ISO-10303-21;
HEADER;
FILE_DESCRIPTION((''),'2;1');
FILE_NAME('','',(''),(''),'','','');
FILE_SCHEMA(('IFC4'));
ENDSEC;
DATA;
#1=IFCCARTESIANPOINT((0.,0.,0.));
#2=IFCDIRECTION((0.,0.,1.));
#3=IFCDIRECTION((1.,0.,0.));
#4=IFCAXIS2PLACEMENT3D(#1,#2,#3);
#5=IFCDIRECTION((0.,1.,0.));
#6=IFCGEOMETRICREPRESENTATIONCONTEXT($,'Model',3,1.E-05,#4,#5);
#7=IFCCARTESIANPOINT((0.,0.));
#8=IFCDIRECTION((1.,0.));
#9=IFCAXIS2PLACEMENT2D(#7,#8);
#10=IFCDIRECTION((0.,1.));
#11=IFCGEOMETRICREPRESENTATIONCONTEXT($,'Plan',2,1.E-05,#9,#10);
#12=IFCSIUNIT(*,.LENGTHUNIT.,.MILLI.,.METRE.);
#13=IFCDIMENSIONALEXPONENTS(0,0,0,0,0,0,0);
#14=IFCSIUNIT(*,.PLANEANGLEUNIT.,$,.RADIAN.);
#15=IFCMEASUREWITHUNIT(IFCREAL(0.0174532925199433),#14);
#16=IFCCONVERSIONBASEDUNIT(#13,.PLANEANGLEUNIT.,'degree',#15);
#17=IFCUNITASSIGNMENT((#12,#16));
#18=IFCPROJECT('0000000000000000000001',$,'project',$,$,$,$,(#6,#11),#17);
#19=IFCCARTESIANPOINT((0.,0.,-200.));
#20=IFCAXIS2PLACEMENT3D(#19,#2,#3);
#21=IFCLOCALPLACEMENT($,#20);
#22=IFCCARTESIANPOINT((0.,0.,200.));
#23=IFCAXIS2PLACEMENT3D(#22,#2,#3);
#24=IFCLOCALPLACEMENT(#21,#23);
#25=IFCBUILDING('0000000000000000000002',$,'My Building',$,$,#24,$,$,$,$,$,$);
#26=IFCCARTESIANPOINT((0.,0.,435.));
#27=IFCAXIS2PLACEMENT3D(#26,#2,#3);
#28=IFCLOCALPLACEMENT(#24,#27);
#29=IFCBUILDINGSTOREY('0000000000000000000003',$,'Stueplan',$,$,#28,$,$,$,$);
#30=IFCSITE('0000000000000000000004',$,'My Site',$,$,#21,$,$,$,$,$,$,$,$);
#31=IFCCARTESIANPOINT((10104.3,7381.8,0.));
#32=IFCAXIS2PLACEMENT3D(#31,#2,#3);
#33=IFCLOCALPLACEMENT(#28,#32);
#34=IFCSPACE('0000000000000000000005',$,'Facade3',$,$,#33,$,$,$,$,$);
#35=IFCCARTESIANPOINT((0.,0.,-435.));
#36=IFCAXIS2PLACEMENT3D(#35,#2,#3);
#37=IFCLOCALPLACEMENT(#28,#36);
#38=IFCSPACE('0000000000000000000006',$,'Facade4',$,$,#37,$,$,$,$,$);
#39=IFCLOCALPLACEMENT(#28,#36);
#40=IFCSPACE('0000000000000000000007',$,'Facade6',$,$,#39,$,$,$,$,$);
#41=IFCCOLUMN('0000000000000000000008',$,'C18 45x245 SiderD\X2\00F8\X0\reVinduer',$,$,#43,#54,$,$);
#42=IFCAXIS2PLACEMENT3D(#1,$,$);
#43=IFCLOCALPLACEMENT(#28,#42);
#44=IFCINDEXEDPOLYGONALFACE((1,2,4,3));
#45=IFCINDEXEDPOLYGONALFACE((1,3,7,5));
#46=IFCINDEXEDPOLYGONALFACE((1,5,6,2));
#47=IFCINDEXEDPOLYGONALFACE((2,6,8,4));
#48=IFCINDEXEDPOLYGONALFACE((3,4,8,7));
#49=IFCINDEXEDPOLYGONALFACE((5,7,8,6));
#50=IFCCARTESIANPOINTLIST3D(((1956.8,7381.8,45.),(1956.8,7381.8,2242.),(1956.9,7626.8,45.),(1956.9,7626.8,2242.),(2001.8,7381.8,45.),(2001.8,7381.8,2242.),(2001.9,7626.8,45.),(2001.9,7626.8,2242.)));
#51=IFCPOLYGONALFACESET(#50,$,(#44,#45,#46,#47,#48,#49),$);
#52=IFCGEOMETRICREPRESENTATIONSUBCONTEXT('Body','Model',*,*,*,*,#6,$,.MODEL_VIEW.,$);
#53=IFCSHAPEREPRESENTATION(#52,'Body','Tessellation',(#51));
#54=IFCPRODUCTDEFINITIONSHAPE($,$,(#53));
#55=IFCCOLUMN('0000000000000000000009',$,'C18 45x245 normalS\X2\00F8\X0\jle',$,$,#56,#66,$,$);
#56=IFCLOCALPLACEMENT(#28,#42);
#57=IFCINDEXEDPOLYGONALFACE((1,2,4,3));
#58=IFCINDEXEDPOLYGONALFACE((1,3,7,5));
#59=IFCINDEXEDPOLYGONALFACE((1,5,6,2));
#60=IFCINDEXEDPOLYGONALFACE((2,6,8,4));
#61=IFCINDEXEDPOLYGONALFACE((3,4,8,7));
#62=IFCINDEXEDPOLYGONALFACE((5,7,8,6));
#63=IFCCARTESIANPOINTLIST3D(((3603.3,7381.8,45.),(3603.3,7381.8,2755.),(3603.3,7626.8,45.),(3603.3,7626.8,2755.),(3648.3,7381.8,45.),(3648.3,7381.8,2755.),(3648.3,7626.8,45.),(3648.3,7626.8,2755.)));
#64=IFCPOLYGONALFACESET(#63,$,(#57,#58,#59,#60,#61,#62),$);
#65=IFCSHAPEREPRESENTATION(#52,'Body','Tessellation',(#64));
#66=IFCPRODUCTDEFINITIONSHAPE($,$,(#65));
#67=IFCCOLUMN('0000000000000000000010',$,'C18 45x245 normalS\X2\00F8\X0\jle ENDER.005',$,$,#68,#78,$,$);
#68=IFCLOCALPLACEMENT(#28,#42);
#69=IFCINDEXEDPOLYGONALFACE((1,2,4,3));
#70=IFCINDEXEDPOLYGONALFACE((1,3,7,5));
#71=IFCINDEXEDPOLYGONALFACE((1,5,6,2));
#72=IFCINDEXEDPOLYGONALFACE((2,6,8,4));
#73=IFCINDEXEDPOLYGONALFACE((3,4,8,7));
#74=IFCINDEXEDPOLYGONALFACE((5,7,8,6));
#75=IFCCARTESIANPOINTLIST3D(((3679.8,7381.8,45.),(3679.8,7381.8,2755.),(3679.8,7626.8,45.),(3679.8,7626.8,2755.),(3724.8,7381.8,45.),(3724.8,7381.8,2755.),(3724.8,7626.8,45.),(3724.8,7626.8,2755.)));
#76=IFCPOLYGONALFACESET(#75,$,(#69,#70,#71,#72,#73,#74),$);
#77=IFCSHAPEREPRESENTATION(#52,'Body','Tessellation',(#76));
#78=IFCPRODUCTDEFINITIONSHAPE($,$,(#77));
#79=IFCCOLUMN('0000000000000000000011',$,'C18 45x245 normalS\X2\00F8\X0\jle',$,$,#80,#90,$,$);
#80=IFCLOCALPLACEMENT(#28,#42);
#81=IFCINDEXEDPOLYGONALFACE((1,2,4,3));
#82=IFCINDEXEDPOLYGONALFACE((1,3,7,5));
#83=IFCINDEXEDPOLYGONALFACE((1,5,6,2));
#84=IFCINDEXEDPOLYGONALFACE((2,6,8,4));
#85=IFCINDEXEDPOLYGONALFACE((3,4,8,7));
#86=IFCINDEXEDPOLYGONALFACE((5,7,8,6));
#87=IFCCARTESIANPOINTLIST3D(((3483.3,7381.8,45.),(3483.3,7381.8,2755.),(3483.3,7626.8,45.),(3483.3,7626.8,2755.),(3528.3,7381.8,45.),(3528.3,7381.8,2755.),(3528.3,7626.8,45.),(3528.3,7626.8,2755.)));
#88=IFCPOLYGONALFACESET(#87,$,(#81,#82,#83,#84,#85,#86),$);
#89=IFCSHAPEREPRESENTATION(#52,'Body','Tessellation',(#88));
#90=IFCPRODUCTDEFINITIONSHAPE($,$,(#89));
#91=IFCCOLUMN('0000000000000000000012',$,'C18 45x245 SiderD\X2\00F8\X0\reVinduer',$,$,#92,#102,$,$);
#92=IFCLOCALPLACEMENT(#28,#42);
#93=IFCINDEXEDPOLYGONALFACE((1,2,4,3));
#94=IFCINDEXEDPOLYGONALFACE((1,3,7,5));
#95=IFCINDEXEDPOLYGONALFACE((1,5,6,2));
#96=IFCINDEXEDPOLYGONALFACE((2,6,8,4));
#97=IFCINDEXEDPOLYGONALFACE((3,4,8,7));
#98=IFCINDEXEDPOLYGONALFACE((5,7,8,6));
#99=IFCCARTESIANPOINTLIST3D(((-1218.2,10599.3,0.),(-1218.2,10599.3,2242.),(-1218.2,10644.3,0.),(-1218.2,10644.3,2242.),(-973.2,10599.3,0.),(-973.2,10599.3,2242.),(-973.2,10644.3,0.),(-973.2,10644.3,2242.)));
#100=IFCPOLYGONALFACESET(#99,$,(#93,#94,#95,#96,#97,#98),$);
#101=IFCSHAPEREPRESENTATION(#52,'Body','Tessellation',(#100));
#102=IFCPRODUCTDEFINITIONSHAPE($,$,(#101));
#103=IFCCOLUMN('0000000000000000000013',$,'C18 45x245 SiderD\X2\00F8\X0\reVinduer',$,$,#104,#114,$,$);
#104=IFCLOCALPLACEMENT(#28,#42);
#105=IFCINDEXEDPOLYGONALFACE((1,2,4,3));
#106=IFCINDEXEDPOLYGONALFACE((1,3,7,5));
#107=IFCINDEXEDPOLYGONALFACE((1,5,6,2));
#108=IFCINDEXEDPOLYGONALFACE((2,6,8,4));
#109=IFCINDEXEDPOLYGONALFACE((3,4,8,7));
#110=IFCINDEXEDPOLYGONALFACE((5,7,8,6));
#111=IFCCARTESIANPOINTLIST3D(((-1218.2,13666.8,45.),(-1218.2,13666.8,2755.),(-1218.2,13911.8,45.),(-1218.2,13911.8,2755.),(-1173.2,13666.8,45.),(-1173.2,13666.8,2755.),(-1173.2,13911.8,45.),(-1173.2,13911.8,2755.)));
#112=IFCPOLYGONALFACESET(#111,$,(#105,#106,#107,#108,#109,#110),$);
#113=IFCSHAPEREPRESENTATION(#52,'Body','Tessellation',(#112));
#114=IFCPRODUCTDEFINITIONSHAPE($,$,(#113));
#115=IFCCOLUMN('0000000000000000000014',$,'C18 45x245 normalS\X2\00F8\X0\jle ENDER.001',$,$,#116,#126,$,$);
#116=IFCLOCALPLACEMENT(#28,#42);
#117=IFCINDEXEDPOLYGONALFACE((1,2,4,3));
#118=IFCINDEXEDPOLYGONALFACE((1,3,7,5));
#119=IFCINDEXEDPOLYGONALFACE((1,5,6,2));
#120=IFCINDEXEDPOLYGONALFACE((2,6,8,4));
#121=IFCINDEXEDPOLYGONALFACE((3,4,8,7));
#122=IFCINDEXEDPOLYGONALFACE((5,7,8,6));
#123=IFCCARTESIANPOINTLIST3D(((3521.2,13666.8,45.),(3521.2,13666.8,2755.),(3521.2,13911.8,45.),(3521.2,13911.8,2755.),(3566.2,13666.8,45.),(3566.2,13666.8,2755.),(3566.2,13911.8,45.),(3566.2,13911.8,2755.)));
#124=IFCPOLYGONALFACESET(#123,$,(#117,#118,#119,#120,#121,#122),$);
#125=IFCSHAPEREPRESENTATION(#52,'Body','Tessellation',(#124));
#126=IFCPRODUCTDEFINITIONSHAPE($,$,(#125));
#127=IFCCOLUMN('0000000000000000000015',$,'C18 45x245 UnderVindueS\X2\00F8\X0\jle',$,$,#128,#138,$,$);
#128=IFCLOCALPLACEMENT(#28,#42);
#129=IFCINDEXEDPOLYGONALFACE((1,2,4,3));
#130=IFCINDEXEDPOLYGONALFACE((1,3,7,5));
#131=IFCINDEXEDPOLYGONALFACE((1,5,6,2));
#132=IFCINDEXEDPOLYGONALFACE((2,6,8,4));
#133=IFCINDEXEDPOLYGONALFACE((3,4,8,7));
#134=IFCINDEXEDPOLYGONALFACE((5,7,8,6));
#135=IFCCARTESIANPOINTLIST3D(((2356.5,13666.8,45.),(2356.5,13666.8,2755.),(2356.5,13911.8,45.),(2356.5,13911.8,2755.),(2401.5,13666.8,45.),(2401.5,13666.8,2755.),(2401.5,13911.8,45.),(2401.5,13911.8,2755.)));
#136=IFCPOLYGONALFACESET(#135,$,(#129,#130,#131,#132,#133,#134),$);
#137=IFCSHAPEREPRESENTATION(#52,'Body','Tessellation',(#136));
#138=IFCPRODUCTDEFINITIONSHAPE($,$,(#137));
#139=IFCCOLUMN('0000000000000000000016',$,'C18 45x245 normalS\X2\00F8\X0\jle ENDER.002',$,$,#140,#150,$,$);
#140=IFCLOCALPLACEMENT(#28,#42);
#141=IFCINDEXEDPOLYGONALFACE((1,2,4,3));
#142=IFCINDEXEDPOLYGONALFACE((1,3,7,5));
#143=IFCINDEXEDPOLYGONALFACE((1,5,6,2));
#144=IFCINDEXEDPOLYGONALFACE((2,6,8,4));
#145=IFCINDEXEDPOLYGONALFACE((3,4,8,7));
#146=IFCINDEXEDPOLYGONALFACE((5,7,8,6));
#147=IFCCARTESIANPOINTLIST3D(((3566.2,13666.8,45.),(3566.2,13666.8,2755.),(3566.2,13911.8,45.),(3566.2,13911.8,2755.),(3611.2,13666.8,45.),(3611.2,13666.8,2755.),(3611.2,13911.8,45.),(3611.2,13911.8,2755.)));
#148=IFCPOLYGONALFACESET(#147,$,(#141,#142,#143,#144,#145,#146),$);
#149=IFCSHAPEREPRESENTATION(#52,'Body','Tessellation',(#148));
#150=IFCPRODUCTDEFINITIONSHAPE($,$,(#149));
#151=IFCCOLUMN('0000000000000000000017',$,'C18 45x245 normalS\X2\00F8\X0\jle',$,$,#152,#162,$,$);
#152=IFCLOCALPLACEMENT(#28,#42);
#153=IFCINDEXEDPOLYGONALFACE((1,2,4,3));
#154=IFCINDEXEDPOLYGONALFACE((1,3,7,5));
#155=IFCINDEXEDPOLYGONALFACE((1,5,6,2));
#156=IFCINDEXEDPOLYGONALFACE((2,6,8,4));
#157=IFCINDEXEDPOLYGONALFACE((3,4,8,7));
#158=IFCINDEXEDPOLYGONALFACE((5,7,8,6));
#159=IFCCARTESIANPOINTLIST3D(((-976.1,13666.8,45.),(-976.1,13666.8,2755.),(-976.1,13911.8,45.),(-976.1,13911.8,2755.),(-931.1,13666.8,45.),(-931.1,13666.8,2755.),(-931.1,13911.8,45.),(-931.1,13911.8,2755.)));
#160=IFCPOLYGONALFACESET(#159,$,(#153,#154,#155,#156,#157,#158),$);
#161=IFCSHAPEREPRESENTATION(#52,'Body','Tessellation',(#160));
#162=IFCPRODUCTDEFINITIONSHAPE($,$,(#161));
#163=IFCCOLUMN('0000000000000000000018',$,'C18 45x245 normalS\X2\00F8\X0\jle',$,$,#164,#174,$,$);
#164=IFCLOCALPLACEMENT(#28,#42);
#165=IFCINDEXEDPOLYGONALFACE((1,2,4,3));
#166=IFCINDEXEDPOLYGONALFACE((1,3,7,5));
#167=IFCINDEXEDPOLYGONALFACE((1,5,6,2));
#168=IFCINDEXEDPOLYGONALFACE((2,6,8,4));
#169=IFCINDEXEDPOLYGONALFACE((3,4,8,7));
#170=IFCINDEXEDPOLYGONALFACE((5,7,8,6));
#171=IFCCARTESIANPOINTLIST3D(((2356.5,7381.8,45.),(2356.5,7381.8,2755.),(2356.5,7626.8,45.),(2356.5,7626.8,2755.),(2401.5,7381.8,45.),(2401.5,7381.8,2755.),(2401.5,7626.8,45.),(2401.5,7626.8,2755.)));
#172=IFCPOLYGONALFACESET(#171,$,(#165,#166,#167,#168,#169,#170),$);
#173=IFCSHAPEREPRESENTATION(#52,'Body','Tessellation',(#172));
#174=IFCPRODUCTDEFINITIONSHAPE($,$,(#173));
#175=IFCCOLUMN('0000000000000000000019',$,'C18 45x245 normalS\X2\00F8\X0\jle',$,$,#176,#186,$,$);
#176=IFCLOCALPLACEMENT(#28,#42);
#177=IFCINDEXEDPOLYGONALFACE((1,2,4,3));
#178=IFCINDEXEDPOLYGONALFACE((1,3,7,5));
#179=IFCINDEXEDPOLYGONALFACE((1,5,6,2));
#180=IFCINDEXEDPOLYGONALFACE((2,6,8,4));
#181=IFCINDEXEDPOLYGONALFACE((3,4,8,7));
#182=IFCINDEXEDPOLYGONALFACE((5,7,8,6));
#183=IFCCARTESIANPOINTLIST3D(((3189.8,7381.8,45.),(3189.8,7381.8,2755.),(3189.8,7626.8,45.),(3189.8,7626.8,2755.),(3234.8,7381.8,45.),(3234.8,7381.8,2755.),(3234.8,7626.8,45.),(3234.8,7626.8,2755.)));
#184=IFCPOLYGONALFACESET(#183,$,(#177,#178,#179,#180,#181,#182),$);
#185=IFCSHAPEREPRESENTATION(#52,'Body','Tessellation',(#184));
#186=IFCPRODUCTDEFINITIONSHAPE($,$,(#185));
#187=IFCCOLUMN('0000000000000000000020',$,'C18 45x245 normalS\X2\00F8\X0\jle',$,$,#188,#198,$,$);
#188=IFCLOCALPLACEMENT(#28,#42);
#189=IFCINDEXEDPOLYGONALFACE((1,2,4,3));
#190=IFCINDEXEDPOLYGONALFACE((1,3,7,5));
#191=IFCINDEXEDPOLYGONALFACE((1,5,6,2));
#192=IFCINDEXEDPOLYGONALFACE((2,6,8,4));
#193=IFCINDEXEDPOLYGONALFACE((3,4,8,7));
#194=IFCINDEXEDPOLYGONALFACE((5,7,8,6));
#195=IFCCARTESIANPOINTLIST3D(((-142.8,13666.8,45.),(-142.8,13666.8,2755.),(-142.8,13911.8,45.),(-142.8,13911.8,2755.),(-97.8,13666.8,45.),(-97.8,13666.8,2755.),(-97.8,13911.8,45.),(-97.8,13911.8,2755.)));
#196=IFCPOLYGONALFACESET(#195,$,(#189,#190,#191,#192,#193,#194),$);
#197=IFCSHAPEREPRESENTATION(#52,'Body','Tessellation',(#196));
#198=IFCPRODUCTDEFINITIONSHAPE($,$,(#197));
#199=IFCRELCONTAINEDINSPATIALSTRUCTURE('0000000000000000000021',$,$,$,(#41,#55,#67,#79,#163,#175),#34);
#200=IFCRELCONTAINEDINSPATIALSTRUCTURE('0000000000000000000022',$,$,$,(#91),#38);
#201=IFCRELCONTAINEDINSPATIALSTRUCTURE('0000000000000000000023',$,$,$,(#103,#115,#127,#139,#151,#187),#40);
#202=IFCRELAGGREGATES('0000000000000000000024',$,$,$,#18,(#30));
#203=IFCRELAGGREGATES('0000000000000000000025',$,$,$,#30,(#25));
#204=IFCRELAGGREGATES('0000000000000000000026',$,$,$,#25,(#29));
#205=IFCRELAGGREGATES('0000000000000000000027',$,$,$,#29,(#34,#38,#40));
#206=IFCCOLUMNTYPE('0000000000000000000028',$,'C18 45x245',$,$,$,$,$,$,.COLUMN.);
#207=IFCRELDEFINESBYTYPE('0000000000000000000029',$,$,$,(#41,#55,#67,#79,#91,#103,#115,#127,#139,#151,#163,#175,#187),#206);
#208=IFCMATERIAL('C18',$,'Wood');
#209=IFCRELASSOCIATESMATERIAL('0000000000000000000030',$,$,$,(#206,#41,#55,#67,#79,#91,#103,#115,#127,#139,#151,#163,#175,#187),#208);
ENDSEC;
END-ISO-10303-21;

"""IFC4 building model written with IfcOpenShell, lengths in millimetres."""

from ifc_helpers import new_model, entity, si_unit, converted_unit, direction, frame, origin_with_axes, origin_2d_with_axis, place, context, subcontext, project, spatial, rectangle, extrude, material, material_profile, profile_set, profile_usage, type_object, element, save


model = new_model("IFC4")

# Units and contexts
model_context = context("Model", 3, precision=1e-05, world=origin_with_axes(), true_north=direction((0.0, 1.0, 0.0)))
plan_context = context("Plan", 2, precision=1e-05, world=origin_2d_with_axis(), true_north=direction((0.0, 1.0)))
body_context_1 = subcontext(model_context, "Body", "Model", "MODEL_VIEW")
ifc_project = project(units=[si_unit("LENGTHUNIT", "METRE", prefix="MILLI"), converted_unit("PLANEANGLEUNIT", "degree", entity("IfcReal", 0.0174532925199433), si_unit("PLANEANGLEUNIT", "RADIAN"), dimensions=[0, 0, 0, 0, 0, 0, 0])], contexts=[model_context, plan_context])

# Site, building, storey, space
site_placement = place(None, frame((0.0, 0.0, -200.0), z_axis=(0.0, 0.0, 1.0), x_axis=(1.0, 0.0, 0.0)))
site = spatial("IfcSite", under=ifc_project, at=site_placement, Name="My Site")
building_placement = place(site_placement, frame((0.0, 0.0, 200.0), z_axis=(0.0, 0.0, 1.0), x_axis=(1.0, 0.0, 0.0)))
building = spatial("IfcBuilding", under=site, at=building_placement, Name="My Building")
storey_placement = place(building_placement, frame((0.0, 0.0, 435.0), z_axis=(0.0, 0.0, 1.0), x_axis=(1.0, 0.0, 0.0)))
storey = spatial("IfcBuildingStorey", under=building, at=storey_placement, Name="Stueplan")
space_1_placement = place(storey_placement, frame((10104.3, 7381.8, 0.0), z_axis=(0.0, 0.0, 1.0), x_axis=(1.0, 0.0, 0.0)))
space_1 = spatial("IfcSpace", under=storey, at=space_1_placement, Name="Facade3")

# Columns
ifc_material_1 = material(Name="C18", Category="Wood")
ifc_material_profile_1 = material_profile(ifc_material_1, rectangle(XDim=45.0, YDim=245.0))
ifc_profile_set_1 = profile_set([ifc_material_profile_1], Name="woodStructural")
ifc_profile_usage_1 = profile_usage(ifc_profile_set_1, cardinal=9)
column_type = type_object("IfcColumnType", Name="C18 45x245", PredefinedType="COLUMN", material=ifc_profile_set_1)
column_1_placement = place(space_1_placement, frame((-8147.5, 245.0, 45.0), z_axis=(0.0, 0.0, 1.0), x_axis=(1.0, 0.0, 0.0)))
element("IfcColumn", 1, at=column_1_placement, inside=space_1, type_object=column_type, material=ifc_profile_usage_1, Name="C18 45x245 SiderDøreVinduer", context=body_context_1, shape_type="SweptSolid", body=[
    extrude(rectangle(XDim=45.0, YDim=245.0), frame((22.5, -122.5, 0.0), z_axis=(0.0, 0.0, 1.0), x_axis=(1.0, 0.0, 0.0)), (0.0, 0.0, 1.0), 2197.0),
])
ifc_profile_usage_2 = profile_usage(ifc_profile_set_1, cardinal=9)
column_2_placement = place(space_1_placement, frame((-6501.1, 245.0, 45.0), z_axis=(0.0, 0.0, 1.0), x_axis=(1.0, 0.0, 0.0)))
element("IfcColumn", 2, at=column_2_placement, inside=space_1, type_object=column_type, material=ifc_profile_usage_2, Name="C18 45x245 normalSøjle", context=body_context_1, shape_type="SweptSolid", body=[
    extrude(rectangle(XDim=45.0, YDim=245.0), frame((22.5, -122.5, 0.0), z_axis=(0.0, 0.0, 1.0), x_axis=(1.0, 0.0, 0.0)), (0.0, 0.0, 1.0), 2710.0),
])
ifc_profile_usage_3 = profile_usage(ifc_profile_set_1, cardinal=9)
column_3_placement = place(space_1_placement, frame((-6424.6, 245.0, 45.0), z_axis=(0.0, 0.0, 1.0), x_axis=(1.0, 0.0, 0.0)))
element("IfcColumn", 3, at=column_3_placement, inside=space_1, type_object=column_type, material=ifc_profile_usage_3, Name="C18 45x245 normalSøjle ENDER.005", context=body_context_1, shape_type="SweptSolid", body=[
    extrude(rectangle(XDim=45.0, YDim=245.0), frame((22.5, -122.5, 0.0), z_axis=(0.0, 0.0, 1.0), x_axis=(1.0, 0.0, 0.0)), (0.0, 0.0, 1.0), 2710.0),
])
ifc_profile_usage_4 = profile_usage(ifc_profile_set_1, cardinal=9)
column_4_placement = place(space_1_placement, frame((-6621.1, 245.0, 45.0), z_axis=(0.0, 0.0, 1.0), x_axis=(1.0, 0.0, 0.0)))
element("IfcColumn", 4, at=column_4_placement, inside=space_1, type_object=column_type, material=ifc_profile_usage_4, Name="C18 45x245 normalSøjle", context=body_context_1, shape_type="SweptSolid", body=[
    extrude(rectangle(XDim=45.0, YDim=245.0), frame((22.5, -122.5, 0.0), z_axis=(0.0, 0.0, 1.0), x_axis=(1.0, 0.0, 0.0)), (0.0, 0.0, 1.0), 2710.0),
])

# Shared definitions
space_2_placement = place(storey_placement, frame((0.0, 0.0, -435.0), z_axis=(0.0, 0.0, 1.0), x_axis=(1.0, 0.0, 0.0)))
space_2 = spatial("IfcSpace", under=storey, at=space_2_placement, Name="Facade4")

# Column
ifc_profile_usage_5 = profile_usage(ifc_profile_set_1, cardinal=9)
column_5_placement = place(space_2_placement, frame((-1218.2, 10599.3, 435.0), z_axis=(0.0, 0.0, 1.0), x_axis=(0.0, 1.0, 0.0)))
element("IfcColumn", 5, at=column_5_placement, inside=space_2, type_object=column_type, material=ifc_profile_usage_5, Name="C18 45x245 SiderDøreVinduer", context=body_context_1, shape_type="SweptSolid", body=[
    extrude(rectangle(XDim=45.0, YDim=245.0), frame((22.5, -122.5, 0.0), z_axis=(0.0, 0.0, 1.0), x_axis=(1.0, 0.0, 0.0)), (0.0, 0.0, 1.0), 2242.0),
])

# Shared definitions
space_3_placement = place(storey_placement, frame((0.0, 0.0, -435.0), z_axis=(0.0, 0.0, 1.0), x_axis=(1.0, 0.0, 0.0)))
space_3 = spatial("IfcSpace", under=storey, at=space_3_placement, Name="Facade6")

# Columns
ifc_profile_usage_6 = profile_usage(ifc_profile_set_1, cardinal=9)
column_6_placement = place(space_3_placement, frame((-1218.2, 13911.8, 480.0), z_axis=(0.0, 0.0, 1.0), x_axis=(1.0, 0.0, 0.0)))
element("IfcColumn", 6, at=column_6_placement, inside=space_3, type_object=column_type, material=ifc_profile_usage_6, Name="C18 45x245 SiderDøreVinduer", context=body_context_1, shape_type="SweptSolid", body=[
    extrude(rectangle(XDim=45.0, YDim=245.0), frame((22.5, -122.5, 0.0), z_axis=(0.0, 0.0, 1.0), x_axis=(1.0, 0.0, 0.0)), (0.0, 0.0, 1.0), 2710.0),
])
ifc_profile_usage_7 = profile_usage(ifc_profile_set_1, cardinal=9)
column_7_placement = place(space_3_placement, frame((3521.2, 13911.8, 480.0), z_axis=(0.0, 0.0, 1.0), x_axis=(1.0, 0.0, 0.0)))
element("IfcColumn", 7, at=column_7_placement, inside=space_3, type_object=column_type, material=ifc_profile_usage_7, Name="C18 45x245 normalSøjle ENDER.001", context=body_context_1, shape_type="SweptSolid", body=[
    extrude(rectangle(XDim=45.0, YDim=245.0), frame((22.5, -122.5, 0.0), z_axis=(0.0, 0.0, 1.0), x_axis=(1.0, 0.0, 0.0)), (0.0, 0.0, 1.0), 2710.0),
])
ifc_profile_usage_8 = profile_usage(ifc_profile_set_1, cardinal=9)
column_8_placement = place(space_3_placement, frame((2356.5, 13911.8, 480.0), z_axis=(0.0, 0.0, 1.0), x_axis=(1.0, 0.0, 0.0)))
element("IfcColumn", 8, at=column_8_placement, inside=space_3, type_object=column_type, material=ifc_profile_usage_8, Name="C18 45x245 UnderVindueSøjle", context=body_context_1, shape_type="SweptSolid", body=[
    extrude(rectangle(XDim=45.0, YDim=245.0), frame((22.5, -122.5, 0.0), z_axis=(0.0, 0.0, 1.0), x_axis=(1.0, 0.0, 0.0)), (0.0, 0.0, 1.0), 2710.0),
])
ifc_profile_usage_9 = profile_usage(ifc_profile_set_1, cardinal=9)
column_9_placement = place(space_3_placement, frame((3566.2, 13911.8, 480.0), z_axis=(0.0, 0.0, 1.0), x_axis=(1.0, 0.0, 0.0)))
element("IfcColumn", 9, at=column_9_placement, inside=space_3, type_object=column_type, material=ifc_profile_usage_9, Name="C18 45x245 normalSøjle ENDER.002", context=body_context_1, shape_type="SweptSolid", body=[
    extrude(rectangle(XDim=45.0, YDim=245.0), frame((22.5, -122.5, 0.0), z_axis=(0.0, 0.0, 1.0), x_axis=(1.0, 0.0, 0.0)), (0.0, 0.0, 1.0), 2710.0),
])
ifc_profile_usage_10 = profile_usage(ifc_profile_set_1, cardinal=9)
column_10_placement = place(space_3_placement, frame((-976.1, 13911.8, 480.0), z_axis=(0.0, 0.0, 1.0), x_axis=(1.0, 0.0, 0.0)))
element("IfcColumn", 10, at=column_10_placement, inside=space_3, type_object=column_type, material=ifc_profile_usage_10, Name="C18 45x245 normalSøjle", context=body_context_1, shape_type="SweptSolid", body=[
    extrude(rectangle(XDim=45.0, YDim=245.0), frame((22.5, -122.5, 0.0), z_axis=(0.0, 0.0, 1.0), x_axis=(1.0, 0.0, 0.0)), (0.0, 0.0, 1.0), 2710.0),
])
ifc_profile_usage_11 = profile_usage(ifc_profile_set_1, cardinal=9)
column_11_placement = place(space_1_placement, frame((-7747.9, 245.0, 45.0), z_axis=(0.0, 0.0, 1.0), x_axis=(1.0, 0.0, 0.0)))
element("IfcColumn", 11, at=column_11_placement, inside=space_1, type_object=column_type, material=ifc_profile_usage_11, Name="C18 45x245 normalSøjle", context=body_context_1, shape_type="SweptSolid", body=[
    extrude(rectangle(XDim=45.0, YDim=245.0), frame((22.5, -122.5, 0.0), z_axis=(0.0, 0.0, 1.0), x_axis=(1.0, 0.0, 0.0)), (0.0, 0.0, 1.0), 2710.0),
])
ifc_profile_usage_12 = profile_usage(ifc_profile_set_1, cardinal=9)
column_12_placement = place(space_1_placement, frame((-6914.5, 245.0, 45.0), z_axis=(0.0, 0.0, 1.0), x_axis=(1.0, 0.0, 0.0)))
element("IfcColumn", 12, at=column_12_placement, inside=space_1, type_object=column_type, material=ifc_profile_usage_12, Name="C18 45x245 normalSøjle", context=body_context_1, shape_type="SweptSolid", body=[
    extrude(rectangle(XDim=45.0, YDim=245.0), frame((22.5, -122.5, 0.0), z_axis=(0.0, 0.0, 1.0), x_axis=(1.0, 0.0, 0.0)), (0.0, 0.0, 1.0), 2710.0),
])
ifc_profile_usage_13 = profile_usage(ifc_profile_set_1, cardinal=9)
column_13_placement = place(space_3_placement, frame((-142.8, 13911.8, 480.0), z_axis=(0.0, 0.0, 1.0), x_axis=(1.0, 0.0, 0.0)))
element("IfcColumn", 13, at=column_13_placement, inside=space_3, type_object=column_type, material=ifc_profile_usage_13, Name="C18 45x245 normalSøjle", context=body_context_1, shape_type="SweptSolid", body=[
    extrude(rectangle(XDim=45.0, YDim=245.0), frame((22.5, -122.5, 0.0), z_axis=(0.0, 0.0, 1.0), x_axis=(1.0, 0.0, 0.0)), (0.0, 0.0, 1.0), 2710.0),
])

save(model, "model.ifc")
